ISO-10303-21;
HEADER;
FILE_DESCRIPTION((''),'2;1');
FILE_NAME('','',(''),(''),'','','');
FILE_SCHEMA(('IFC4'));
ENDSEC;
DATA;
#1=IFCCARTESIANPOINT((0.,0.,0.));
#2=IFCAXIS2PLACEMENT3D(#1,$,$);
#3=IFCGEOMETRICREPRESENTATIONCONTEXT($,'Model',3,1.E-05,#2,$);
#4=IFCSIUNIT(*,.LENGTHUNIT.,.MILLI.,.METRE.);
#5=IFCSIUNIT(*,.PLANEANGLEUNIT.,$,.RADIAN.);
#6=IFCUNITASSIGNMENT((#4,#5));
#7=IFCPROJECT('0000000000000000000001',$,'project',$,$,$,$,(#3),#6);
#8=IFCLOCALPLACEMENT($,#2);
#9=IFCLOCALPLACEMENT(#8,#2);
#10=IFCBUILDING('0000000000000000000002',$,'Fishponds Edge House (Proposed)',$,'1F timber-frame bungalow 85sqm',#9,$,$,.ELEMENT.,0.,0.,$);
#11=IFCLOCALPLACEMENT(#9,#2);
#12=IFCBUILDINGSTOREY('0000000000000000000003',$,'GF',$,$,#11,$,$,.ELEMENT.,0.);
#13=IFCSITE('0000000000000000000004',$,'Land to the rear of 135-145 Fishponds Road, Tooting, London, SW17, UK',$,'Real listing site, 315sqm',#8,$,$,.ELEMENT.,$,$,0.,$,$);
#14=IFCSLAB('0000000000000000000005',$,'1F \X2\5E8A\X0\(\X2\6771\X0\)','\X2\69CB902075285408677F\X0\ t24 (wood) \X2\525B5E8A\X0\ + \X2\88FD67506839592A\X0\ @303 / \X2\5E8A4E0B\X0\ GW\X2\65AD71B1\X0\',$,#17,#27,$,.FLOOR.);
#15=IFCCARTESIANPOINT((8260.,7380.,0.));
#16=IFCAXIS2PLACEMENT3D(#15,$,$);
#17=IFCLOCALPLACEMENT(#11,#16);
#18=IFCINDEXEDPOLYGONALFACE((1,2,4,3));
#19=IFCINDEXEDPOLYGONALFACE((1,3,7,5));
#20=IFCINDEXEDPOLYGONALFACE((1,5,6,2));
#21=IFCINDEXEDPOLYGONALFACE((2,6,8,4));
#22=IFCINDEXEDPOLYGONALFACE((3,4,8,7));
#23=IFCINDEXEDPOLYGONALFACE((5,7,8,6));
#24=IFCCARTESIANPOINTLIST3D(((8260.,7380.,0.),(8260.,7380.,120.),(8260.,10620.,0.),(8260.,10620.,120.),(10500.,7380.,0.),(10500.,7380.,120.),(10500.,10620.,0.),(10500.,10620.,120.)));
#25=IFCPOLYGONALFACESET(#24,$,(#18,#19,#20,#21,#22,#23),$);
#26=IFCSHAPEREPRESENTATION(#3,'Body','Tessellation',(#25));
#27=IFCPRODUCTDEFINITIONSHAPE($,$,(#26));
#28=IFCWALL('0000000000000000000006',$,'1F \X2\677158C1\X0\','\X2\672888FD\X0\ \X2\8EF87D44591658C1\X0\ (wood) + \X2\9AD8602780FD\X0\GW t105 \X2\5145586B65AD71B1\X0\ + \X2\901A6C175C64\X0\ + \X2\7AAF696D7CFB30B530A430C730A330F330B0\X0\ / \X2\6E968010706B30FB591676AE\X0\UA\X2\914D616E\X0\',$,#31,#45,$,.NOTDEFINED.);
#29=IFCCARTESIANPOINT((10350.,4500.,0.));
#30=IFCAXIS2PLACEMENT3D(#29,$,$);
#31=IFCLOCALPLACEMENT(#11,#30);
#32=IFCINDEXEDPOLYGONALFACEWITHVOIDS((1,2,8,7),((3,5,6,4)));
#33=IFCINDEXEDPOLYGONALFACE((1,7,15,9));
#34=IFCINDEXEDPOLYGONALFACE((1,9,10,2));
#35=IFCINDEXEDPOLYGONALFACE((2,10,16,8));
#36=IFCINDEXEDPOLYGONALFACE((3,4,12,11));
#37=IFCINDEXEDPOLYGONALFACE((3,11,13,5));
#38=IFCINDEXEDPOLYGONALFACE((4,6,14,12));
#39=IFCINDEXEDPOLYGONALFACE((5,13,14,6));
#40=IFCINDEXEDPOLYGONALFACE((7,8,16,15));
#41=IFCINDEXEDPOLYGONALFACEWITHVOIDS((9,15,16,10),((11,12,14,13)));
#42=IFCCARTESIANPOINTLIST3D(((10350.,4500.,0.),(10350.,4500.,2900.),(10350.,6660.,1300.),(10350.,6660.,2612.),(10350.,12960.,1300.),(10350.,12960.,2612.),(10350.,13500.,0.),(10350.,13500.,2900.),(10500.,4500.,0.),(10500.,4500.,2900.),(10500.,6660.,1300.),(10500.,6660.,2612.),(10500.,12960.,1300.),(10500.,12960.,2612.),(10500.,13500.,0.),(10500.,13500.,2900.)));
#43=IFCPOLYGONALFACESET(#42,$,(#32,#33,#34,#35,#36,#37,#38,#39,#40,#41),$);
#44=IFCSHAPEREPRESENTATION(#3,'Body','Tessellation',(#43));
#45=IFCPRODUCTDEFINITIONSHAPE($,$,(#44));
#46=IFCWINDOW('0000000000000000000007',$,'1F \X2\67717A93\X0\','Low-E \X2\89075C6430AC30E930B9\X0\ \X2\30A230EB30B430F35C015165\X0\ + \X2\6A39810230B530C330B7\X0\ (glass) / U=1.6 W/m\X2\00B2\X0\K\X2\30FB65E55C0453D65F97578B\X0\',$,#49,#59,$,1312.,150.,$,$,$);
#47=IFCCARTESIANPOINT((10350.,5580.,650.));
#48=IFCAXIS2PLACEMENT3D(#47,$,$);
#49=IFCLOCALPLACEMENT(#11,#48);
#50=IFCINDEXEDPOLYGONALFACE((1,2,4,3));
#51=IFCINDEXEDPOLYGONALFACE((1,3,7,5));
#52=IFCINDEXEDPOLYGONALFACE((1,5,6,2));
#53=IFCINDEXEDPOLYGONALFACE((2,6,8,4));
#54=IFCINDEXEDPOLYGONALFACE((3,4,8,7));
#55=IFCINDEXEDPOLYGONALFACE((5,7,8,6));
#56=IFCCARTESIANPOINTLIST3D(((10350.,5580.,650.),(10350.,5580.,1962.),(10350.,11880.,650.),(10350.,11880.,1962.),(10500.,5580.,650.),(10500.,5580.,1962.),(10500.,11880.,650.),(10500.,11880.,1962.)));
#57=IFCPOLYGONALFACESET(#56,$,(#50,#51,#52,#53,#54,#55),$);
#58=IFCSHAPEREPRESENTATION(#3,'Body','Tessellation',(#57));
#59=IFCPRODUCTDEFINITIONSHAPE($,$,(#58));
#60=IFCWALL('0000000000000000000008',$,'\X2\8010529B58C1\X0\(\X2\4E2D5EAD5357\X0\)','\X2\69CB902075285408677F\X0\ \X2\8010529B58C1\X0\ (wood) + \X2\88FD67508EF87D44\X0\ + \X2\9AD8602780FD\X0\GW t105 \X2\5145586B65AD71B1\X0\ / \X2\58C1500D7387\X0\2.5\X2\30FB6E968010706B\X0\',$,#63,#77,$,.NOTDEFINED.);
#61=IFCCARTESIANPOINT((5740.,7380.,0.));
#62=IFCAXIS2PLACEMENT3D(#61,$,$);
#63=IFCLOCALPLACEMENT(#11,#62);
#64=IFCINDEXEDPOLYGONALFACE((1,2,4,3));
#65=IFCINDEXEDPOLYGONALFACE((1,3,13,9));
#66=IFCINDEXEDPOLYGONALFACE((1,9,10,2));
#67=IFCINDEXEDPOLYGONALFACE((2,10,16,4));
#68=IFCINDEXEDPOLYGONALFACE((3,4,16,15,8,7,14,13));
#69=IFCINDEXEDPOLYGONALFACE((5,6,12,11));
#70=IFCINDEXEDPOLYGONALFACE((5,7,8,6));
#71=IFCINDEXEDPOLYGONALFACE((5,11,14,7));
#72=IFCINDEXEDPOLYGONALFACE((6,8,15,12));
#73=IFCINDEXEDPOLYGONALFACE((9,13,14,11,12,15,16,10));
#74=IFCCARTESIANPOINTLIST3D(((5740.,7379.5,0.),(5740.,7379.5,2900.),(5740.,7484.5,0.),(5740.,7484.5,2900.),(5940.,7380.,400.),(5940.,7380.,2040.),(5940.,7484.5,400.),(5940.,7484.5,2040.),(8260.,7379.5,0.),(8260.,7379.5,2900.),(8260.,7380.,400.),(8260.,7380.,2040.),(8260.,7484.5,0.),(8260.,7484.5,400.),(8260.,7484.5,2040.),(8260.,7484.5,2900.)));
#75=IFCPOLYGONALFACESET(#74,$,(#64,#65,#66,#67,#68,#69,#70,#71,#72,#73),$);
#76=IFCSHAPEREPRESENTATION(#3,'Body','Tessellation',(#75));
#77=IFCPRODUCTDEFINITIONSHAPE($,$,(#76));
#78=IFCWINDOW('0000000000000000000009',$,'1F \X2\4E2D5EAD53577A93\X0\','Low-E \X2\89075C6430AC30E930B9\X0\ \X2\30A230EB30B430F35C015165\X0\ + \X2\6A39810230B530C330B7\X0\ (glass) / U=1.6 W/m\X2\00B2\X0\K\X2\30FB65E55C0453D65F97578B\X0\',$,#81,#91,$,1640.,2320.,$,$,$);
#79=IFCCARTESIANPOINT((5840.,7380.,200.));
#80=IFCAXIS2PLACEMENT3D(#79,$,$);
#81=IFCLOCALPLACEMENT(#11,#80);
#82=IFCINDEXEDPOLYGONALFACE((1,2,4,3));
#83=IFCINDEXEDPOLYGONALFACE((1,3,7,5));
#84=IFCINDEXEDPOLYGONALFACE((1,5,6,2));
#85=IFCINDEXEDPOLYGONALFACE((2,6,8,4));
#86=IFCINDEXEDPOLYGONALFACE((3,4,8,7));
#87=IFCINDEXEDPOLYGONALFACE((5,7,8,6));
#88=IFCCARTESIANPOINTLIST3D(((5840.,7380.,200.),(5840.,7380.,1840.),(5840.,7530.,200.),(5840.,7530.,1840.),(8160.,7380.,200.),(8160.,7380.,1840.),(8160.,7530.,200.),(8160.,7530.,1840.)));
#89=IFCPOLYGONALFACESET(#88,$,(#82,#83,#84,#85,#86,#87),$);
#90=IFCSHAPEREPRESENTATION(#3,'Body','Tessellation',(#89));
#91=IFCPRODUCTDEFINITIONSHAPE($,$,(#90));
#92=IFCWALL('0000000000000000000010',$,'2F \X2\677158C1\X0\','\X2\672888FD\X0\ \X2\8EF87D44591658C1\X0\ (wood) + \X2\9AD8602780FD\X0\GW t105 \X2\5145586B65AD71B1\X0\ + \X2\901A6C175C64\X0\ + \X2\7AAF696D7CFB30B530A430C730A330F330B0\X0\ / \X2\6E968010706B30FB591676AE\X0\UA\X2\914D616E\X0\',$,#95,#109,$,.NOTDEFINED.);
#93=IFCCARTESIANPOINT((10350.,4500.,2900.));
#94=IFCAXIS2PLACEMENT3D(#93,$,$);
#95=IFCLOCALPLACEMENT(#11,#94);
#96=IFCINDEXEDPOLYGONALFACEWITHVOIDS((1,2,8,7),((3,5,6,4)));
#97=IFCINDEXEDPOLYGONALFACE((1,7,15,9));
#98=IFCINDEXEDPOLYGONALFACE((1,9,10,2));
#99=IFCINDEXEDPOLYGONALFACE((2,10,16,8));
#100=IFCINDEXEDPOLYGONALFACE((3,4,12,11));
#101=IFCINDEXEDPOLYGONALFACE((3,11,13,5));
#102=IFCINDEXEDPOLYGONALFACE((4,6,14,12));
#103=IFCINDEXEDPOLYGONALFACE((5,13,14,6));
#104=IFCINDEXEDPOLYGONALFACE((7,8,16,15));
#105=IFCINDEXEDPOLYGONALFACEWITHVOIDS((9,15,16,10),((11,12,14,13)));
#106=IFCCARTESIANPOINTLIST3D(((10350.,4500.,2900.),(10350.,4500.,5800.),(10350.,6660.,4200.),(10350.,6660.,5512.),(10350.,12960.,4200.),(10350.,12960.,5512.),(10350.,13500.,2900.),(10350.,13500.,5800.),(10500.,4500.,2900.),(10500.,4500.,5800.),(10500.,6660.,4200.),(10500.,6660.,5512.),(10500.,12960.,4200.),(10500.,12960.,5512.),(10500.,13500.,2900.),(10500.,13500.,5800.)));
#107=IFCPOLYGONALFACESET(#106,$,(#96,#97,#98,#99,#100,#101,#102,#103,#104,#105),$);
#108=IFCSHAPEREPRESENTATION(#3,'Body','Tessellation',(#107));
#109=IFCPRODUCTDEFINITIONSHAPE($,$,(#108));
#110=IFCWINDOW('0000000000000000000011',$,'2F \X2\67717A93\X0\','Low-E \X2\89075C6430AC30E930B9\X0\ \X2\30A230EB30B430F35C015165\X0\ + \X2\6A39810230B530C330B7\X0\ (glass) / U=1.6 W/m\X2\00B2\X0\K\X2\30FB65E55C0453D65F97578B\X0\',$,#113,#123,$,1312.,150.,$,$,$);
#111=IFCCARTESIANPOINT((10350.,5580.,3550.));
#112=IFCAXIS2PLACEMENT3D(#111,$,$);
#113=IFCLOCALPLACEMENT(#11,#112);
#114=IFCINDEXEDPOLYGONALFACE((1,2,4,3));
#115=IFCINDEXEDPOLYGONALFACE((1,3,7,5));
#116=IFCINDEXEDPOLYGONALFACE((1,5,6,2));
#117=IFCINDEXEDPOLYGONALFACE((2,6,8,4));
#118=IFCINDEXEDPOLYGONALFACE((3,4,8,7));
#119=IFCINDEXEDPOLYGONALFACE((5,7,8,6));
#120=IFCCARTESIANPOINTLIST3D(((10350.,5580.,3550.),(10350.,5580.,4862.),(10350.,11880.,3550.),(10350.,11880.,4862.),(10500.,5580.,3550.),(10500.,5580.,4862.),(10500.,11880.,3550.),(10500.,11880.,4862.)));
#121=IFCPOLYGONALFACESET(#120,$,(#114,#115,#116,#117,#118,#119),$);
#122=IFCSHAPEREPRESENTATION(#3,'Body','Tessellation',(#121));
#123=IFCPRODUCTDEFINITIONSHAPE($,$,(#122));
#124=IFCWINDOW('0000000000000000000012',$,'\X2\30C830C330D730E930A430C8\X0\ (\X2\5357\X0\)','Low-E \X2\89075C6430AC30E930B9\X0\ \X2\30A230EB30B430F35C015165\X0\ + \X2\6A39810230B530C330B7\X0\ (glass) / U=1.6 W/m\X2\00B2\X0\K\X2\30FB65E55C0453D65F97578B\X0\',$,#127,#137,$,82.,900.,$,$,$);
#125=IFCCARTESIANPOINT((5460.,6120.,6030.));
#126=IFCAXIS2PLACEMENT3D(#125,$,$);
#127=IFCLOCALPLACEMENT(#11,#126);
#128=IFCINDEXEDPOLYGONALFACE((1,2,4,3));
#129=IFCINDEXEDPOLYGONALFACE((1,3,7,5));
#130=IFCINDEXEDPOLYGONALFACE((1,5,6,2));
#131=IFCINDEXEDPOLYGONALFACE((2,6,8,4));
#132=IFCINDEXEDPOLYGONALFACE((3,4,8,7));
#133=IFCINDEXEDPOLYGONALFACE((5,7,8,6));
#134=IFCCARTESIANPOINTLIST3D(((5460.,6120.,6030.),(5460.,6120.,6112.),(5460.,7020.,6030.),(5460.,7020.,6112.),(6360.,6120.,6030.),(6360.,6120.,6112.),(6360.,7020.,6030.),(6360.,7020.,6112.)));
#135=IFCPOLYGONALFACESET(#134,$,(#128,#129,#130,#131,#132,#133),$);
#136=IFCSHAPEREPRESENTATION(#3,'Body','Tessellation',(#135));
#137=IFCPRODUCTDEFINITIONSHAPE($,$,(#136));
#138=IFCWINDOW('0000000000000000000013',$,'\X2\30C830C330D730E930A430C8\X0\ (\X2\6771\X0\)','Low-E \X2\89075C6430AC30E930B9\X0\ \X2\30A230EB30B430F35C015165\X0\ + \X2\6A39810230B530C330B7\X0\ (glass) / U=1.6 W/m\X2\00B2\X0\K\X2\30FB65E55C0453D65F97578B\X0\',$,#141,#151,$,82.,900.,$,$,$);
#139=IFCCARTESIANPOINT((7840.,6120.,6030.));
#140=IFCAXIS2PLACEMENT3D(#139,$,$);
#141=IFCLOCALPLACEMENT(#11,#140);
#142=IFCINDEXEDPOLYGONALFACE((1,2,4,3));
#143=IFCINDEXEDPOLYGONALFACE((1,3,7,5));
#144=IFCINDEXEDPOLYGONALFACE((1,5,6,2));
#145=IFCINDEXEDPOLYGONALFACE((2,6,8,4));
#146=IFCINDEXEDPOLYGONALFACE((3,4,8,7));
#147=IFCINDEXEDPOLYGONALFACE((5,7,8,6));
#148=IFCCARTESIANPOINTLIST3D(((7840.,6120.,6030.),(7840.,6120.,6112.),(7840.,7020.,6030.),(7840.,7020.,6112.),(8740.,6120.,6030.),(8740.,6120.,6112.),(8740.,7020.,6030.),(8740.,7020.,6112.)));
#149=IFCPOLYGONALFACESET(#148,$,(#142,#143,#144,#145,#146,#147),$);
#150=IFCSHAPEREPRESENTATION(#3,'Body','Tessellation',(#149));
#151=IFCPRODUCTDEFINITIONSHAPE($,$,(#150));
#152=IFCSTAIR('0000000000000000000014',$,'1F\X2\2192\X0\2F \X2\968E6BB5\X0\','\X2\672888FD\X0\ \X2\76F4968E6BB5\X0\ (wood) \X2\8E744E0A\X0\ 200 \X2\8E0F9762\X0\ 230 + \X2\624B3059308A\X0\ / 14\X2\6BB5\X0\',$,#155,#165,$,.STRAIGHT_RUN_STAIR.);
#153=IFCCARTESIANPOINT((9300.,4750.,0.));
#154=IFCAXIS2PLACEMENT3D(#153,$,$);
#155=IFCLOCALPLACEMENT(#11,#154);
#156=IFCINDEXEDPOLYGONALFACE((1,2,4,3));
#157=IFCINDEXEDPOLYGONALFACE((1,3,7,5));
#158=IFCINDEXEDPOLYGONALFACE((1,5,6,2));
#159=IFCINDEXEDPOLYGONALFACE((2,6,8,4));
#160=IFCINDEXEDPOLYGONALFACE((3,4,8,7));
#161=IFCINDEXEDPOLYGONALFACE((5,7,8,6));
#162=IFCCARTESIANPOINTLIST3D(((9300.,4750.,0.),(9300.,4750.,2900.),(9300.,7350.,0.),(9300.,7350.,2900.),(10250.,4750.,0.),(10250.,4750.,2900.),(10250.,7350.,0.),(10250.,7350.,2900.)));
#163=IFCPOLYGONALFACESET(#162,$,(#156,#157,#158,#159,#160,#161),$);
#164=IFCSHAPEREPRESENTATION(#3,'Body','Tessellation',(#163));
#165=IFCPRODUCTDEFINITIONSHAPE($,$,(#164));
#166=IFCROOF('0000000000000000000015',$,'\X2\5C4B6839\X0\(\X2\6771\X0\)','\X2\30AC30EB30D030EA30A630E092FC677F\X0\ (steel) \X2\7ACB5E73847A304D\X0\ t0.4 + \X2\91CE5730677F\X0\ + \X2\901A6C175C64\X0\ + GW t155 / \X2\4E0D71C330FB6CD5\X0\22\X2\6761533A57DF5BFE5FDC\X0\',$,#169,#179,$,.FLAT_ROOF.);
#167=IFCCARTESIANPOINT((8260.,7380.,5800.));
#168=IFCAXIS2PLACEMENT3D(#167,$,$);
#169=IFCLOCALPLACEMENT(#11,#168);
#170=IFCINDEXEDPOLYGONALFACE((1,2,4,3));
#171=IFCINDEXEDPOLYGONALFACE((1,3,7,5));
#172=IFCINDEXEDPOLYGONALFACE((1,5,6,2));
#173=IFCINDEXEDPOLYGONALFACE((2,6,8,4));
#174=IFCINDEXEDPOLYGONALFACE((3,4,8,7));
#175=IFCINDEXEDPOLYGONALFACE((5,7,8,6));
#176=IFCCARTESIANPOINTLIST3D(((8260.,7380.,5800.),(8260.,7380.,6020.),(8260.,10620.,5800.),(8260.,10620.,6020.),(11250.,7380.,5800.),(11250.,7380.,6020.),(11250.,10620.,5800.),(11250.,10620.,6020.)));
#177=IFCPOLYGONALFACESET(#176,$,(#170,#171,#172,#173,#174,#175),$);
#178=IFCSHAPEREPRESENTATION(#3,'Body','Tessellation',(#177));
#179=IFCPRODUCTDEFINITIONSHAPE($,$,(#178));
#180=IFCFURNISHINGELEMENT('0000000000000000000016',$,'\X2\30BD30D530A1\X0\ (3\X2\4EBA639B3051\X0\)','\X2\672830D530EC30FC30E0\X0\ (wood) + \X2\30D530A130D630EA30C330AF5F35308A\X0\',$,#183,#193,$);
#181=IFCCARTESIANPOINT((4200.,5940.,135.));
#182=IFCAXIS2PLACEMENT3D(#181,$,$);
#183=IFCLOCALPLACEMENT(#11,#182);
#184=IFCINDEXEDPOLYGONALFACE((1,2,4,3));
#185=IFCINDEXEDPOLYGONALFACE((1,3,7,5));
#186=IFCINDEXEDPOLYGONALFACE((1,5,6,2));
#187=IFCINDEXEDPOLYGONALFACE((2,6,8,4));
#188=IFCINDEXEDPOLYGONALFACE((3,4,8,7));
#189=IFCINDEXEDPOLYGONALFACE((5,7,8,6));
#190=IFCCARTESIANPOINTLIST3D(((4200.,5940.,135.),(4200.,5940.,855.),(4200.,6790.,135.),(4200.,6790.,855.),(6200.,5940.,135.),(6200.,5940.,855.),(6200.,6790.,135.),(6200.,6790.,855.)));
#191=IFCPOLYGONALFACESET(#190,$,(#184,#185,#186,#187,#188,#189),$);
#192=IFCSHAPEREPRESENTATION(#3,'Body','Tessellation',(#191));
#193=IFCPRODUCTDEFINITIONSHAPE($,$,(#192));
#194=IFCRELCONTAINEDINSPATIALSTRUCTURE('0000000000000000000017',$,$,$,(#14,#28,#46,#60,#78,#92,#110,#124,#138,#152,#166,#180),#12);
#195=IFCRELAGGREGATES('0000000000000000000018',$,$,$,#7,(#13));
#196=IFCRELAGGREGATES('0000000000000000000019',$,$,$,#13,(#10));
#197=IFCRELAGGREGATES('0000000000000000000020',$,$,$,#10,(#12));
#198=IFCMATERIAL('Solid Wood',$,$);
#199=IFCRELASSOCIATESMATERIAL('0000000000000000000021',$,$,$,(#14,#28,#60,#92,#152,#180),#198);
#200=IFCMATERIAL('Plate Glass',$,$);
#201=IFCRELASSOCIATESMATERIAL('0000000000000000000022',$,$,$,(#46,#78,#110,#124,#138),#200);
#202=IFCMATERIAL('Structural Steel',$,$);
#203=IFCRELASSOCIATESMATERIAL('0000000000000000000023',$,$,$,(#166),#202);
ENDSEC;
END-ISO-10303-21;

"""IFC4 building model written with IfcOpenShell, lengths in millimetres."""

from ifc_helpers import new_model, si_unit, frame, frame_2d, origin, place, context, project, spatial, rectangle, extrude, material, element, fill, save


model = new_model("IFC4")

# Units and contexts
model_context = context("Model", 3, precision=1e-05, world=origin())
ifc_project = project(units=[si_unit("LENGTHUNIT", "METRE", prefix="MILLI"), si_unit("PLANEANGLEUNIT", "RADIAN")], contexts=[model_context])

# Site, building, storey
site_placement = place(None, origin())
site = spatial("IfcSite", under=ifc_project, at=site_placement, Name="Land to the rear of 135-145 Fishponds Road, Tooting, London, SW17, UK", ObjectType="Real listing site, 315sqm", CompositionType="ELEMENT", RefElevation=0.0)
building_placement = place(site_placement, origin())
building = spatial("IfcBuilding", under=site, at=building_placement, Name="Fishponds Edge House (Proposed)", ObjectType="1F timber-frame bungalow 85sqm", CompositionType="ELEMENT", ElevationOfRefHeight=0.0, ElevationOfTerrain=0.0)
storey_placement = place(building_placement, origin())
storey = spatial("IfcBuildingStorey", under=building, at=storey_placement, Name="GF", CompositionType="ELEMENT", Elevation=0.0)

# Slab
ifc_material_1 = material(Name="Solid Wood")
slab_placement = place(storey_placement, frame((8260.0, 7380.0, 0.0)))
element("IfcSlab", 1, at=slab_placement, inside=storey, material=ifc_material_1, Name="1F 床(東)", Description="構造用合板 t24 (wood) 剛床 + 製材根太 @303 / 床下 GW断熱", PredefinedType="FLOOR", context=model_context, shape_type="SweptSolid", body=[
    extrude(rectangle(XDim=2240.0, YDim=3240.0, at=frame_2d((1120.0, 1620.0))), frame((8260.0, 7380.0, 0.0)), (0.0, 0.0, 1.0), 120.0),
])

# Walls, openings, windows
wall_1_placement = place(storey_placement, frame((10350.0, 4500.0, 0.0)))
wall_1 = element("IfcWall", 2, at=wall_1_placement, inside=storey, material=ifc_material_1, Name="1F 東壁", Description="木製 軸組外壁 (wood) + 高性能GW t105 充填断熱 + 通気層 + 窯業系サイディング / 準耐火・外皮UA配慮", PredefinedType="NOTDEFINED", context=model_context, shape_type="SweptSolid", body=[
    extrude(rectangle(XDim=150.0, YDim=9000.0, at=frame_2d((75.0, 4500.0))), frame((10350.0, 4500.0, 0.0)), (0.0, 0.0, 1.0), 2900.0),
])
opening_1_placement = place(storey_placement, frame((10350.0, 5580.0, 650.0)))
opening_1 = element("IfcOpeningElement", 3, at=opening_1_placement, cuts=wall_1, PredefinedType="NOTDEFINED", context=model_context, shape_type="SweptSolid", body=[
    extrude(rectangle(XDim=150.0, YDim=6300.0, at=frame_2d((75.0, 3150.0))), frame((10350.0, 5580.0, 650.0)), (0.0, 0.0, 1.0), 1312.0),
])
ifc_material_2 = material(Name="Plate Glass")
window_1_placement = place(storey_placement, frame((10350.0, 5580.0, 650.0)))
window_1 = element("IfcWindow", 4, at=window_1_placement, inside=storey, material=ifc_material_2, Name="1F 東窓", Description="Low-E 複層ガラス アルゴン封入 + 樹脂サッシ (glass) / U=1.6 W/m²K・日射取得型", OverallHeight=1312.0, OverallWidth=150.0, context=model_context, shape_type="SweptSolid", body=[
    extrude(rectangle(XDim=150.0, YDim=6300.0, at=frame_2d((75.0, 3150.0))), frame((10350.0, 5580.0, 650.0)), (0.0, 0.0, 1.0), 1312.0),
])
fill(opening_1, window_1)
wall_2_placement = place(storey_placement, frame((5740.0, 7380.0, 0.0)))
wall_2 = element("IfcWall", 5, at=wall_2_placement, inside=storey, material=ifc_material_1, Name="耐力壁(中庭南)", Description="構造用合板 耐力壁 (wood) + 製材軸組 + 高性能GW t105 充填断熱 / 壁倍率2.5・準耐火", PredefinedType="NOTDEFINED", context=model_context, shape_type="SweptSolid", body=[
    extrude(rectangle(XDim=2520.0, YDim=105.0, at=frame_2d((1260.0, 52.0))), frame((5740.0, 7380.0, 0.0)), (0.0, 0.0, 1.0), 2900.0),
])
opening_2_placement = place(storey_placement, frame((5840.0, 7380.0, 200.0)))
opening_2 = element("IfcOpeningElement", 6, at=opening_2_placement, cuts=wall_2, PredefinedType="NOTDEFINED", context=model_context, shape_type="SweptSolid", body=[
    extrude(rectangle(XDim=2320.0, YDim=150.0, at=frame_2d((1160.0, 75.0))), frame((5840.0, 7380.0, 200.0)), (0.0, 0.0, 1.0), 1640.0),
])
window_2_placement = place(storey_placement, frame((5840.0, 7380.0, 200.0)))
window_2 = element("IfcWindow", 7, at=window_2_placement, inside=storey, material=ifc_material_2, Name="1F 中庭南窓", Description="Low-E 複層ガラス アルゴン封入 + 樹脂サッシ (glass) / U=1.6 W/m²K・日射取得型", OverallHeight=1640.0, OverallWidth=2320.0, context=model_context, shape_type="SweptSolid", body=[
    extrude(rectangle(XDim=2320.0, YDim=150.0, at=frame_2d((1160.0, 75.0))), frame((5840.0, 7380.0, 200.0)), (0.0, 0.0, 1.0), 1640.0),
])
fill(opening_2, window_2)

# Wall, opening, window
wall_3_placement = place(storey_placement, frame((10350.0, 4500.0, 2900.0)))
wall_3 = element("IfcWall", 8, at=wall_3_placement, inside=storey, material=ifc_material_1, Name="2F 東壁", Description="木製 軸組外壁 (wood) + 高性能GW t105 充填断熱 + 通気層 + 窯業系サイディング / 準耐火・外皮UA配慮", PredefinedType="NOTDEFINED", context=model_context, shape_type="SweptSolid", body=[
    extrude(rectangle(XDim=150.0, YDim=9000.0, at=frame_2d((75.0, 4500.0))), frame((10350.0, 4500.0, 2900.0)), (0.0, 0.0, 1.0), 2900.0),
])
opening_3_placement = place(storey_placement, frame((10350.0, 5580.0, 3550.0)))
opening_3 = element("IfcOpeningElement", 9, at=opening_3_placement, cuts=wall_3, PredefinedType="NOTDEFINED", context=model_context, shape_type="SweptSolid", body=[
    extrude(rectangle(XDim=150.0, YDim=6300.0, at=frame_2d((75.0, 3150.0))), frame((10350.0, 5580.0, 3550.0)), (0.0, 0.0, 1.0), 1312.0),
])
window_3_placement = place(storey_placement, frame((10350.0, 5580.0, 3550.0)))
window_3 = element("IfcWindow", 10, at=window_3_placement, inside=storey, material=ifc_material_2, Name="2F 東窓", Description="Low-E 複層ガラス アルゴン封入 + 樹脂サッシ (glass) / U=1.6 W/m²K・日射取得型", OverallHeight=1312.0, OverallWidth=150.0, context=model_context, shape_type="SweptSolid", body=[
    extrude(rectangle(XDim=150.0, YDim=6300.0, at=frame_2d((75.0, 3150.0))), frame((10350.0, 5580.0, 3550.0)), (0.0, 0.0, 1.0), 1312.0),
])
fill(opening_3, window_3)

# Windows
window_4_placement = place(storey_placement, frame((5460.0, 6120.0, 6030.0)))
element("IfcWindow", 11, at=window_4_placement, inside=storey, material=ifc_material_2, Name="トップライト (南)", Description="Low-E 複層ガラス アルゴン封入 + 樹脂サッシ (glass) / U=1.6 W/m²K・日射取得型", OverallHeight=82.0, OverallWidth=900.0, context=model_context, shape_type="SweptSolid", body=[
    extrude(rectangle(XDim=900.0, YDim=900.0, at=frame_2d((450.0, 450.0))), frame((5460.0, 6120.0, 6030.0)), (0.0, 0.0, 1.0), 82.0),
])
window_5_placement = place(storey_placement, frame((7840.0, 6120.0, 6030.0)))
element("IfcWindow", 12, at=window_5_placement, inside=storey, material=ifc_material_2, Name="トップライト (東)", Description="Low-E 複層ガラス アルゴン封入 + 樹脂サッシ (glass) / U=1.6 W/m²K・日射取得型", OverallHeight=82.0, OverallWidth=900.0, context=model_context, shape_type="SweptSolid", body=[
    extrude(rectangle(XDim=900.0, YDim=900.0, at=frame_2d((450.0, 450.0))), frame((7840.0, 6120.0, 6030.0)), (0.0, 0.0, 1.0), 82.0),
])

# Stair
stair_placement = place(storey_placement, frame((9300.0, 4750.0, 0.0)))
element("IfcStair", 13, at=stair_placement, inside=storey, material=ifc_material_1, Name="1F→2F 階段", Description="木製 直階段 (wood) 蹴上 200 踏面 230 + 手すり / 14段", PredefinedType="STRAIGHT_RUN_STAIR", context=model_context, shape_type="SweptSolid", body=[
    extrude(rectangle(XDim=950.0, YDim=2600.0, at=frame_2d((475.0, 1300.0))), frame((9300.0, 4750.0, 0.0)), (0.0, 0.0, 1.0), 2900.0),
])

# Roof
ifc_material_3 = material(Name="Structural Steel")
roof_placement = place(storey_placement, frame((8260.0, 7380.0, 5800.0)))
element("IfcRoof", 14, at=roof_placement, inside=storey, material=ifc_material_3, Name="屋根(東)", Description="ガルバリウム鋼板 (steel) 立平葺き t0.4 + 野地板 + 通気層 + GW t155 / 不燃・法22条区域対応", PredefinedType="FLAT_ROOF", context=model_context, shape_type="SweptSolid", body=[
    extrude(rectangle(XDim=2990.0, YDim=3240.0, at=frame_2d((1495.0, 1620.0))), frame((8260.0, 7380.0, 5800.0)), (0.0, 0.0, 1.0), 220.0),
])

# Furnishing element
furnishing_1_placement = place(storey_placement, frame((4200.0, 5940.0, 135.0)))
element("IfcFurnishingElement", 15, at=furnishing_1_placement, inside=storey, material=ifc_material_1, Name="ソファ (3人掛け)", Description="木フレーム (wood) + ファブリック張り", context=model_context, shape_type="SweptSolid", body=[
    extrude(rectangle(XDim=2000.0, YDim=850.0, at=frame_2d((1000.0, 425.0))), frame((4200.0, 5940.0, 135.0)), (0.0, 0.0, 1.0), 720.0),
])

save(model, "model.ifc")
